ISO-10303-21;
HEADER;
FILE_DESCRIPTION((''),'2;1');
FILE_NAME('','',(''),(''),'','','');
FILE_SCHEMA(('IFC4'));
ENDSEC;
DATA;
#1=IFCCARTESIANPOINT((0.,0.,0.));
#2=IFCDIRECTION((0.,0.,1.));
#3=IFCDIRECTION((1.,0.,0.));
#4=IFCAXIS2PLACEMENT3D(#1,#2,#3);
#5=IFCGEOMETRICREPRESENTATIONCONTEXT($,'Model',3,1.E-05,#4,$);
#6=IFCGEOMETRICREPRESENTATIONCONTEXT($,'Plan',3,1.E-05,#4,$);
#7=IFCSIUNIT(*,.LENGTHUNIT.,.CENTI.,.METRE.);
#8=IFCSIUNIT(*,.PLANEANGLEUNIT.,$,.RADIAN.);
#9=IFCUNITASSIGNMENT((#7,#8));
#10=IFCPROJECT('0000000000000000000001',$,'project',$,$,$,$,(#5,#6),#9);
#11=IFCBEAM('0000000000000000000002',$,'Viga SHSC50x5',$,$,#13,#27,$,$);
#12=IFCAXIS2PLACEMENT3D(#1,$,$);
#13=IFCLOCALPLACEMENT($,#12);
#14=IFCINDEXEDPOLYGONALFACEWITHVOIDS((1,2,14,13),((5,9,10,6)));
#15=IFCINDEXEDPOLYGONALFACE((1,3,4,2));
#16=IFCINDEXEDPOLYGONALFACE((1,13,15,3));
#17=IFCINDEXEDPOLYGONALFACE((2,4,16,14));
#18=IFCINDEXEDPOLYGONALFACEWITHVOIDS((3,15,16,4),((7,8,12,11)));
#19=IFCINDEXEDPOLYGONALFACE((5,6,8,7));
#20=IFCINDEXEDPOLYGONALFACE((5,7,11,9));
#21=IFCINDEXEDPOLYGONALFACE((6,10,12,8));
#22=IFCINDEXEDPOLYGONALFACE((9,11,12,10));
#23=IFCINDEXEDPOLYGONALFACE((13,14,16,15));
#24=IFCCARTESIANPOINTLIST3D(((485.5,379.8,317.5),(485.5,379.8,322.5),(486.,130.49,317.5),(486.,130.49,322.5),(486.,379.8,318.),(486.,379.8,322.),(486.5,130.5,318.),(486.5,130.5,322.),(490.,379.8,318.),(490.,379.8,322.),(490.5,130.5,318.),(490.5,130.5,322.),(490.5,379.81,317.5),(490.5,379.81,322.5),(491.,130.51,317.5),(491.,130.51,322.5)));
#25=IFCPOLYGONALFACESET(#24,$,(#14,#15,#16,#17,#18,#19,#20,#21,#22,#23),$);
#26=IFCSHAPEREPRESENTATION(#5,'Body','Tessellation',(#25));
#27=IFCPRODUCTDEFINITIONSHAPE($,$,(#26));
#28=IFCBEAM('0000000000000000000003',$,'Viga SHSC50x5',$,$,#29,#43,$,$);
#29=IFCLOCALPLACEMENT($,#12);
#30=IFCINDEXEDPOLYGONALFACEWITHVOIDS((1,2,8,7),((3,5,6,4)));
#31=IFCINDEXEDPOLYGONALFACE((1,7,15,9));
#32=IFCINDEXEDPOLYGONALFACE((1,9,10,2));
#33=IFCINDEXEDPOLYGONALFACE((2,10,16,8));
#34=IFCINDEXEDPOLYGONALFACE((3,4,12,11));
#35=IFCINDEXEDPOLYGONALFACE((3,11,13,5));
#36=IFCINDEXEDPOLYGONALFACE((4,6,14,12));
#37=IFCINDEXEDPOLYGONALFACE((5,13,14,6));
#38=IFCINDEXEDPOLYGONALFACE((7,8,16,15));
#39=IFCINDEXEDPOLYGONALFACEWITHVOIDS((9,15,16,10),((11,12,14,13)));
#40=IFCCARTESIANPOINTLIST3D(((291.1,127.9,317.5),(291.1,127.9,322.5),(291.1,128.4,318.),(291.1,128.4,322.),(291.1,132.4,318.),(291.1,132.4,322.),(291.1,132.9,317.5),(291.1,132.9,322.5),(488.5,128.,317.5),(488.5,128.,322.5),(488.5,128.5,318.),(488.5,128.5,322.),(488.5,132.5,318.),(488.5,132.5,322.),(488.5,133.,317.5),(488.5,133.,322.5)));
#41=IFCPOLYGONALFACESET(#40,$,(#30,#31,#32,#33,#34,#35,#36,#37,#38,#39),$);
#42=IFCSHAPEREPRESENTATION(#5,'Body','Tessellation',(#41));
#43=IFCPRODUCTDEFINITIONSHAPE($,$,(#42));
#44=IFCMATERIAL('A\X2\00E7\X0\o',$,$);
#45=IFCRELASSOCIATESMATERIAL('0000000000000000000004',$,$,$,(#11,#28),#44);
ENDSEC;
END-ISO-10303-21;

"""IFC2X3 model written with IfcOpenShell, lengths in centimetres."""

from ifc_helpers import new_model, si_unit, frame, frame_2d, origin_with_axes, place, context, project, polyline, rectangle, outline, extrude, material, element, save


model = new_model("IFC2X3")

# Units and contexts
model_context = context("Model", 3, precision=1e-05, world=origin_with_axes())
plan_context = context("Plan", 3, precision=1e-05, world=origin_with_axes())
ifc_project = project(units=[si_unit("LENGTHUNIT", "METRE", prefix="CENTI"), si_unit("PLANEANGLEUNIT", "RADIAN")], contexts=[model_context, plan_context])

# Shared definitions
ifc_material = material(Name="Aço")

# Beams, openings
placement_1 = place(None, frame((488.5, 130.5, 320.0), z_axis=(-0.002006, 0.999998, 0.0), x_axis=(0.999998, 0.002006, 0.0)))
beam_1 = element("IfcBeam", 1, at=placement_1, material=ifc_material, Name="Viga SHSC50x5", context=model_context, shape_type="SweptSolid", body=[
    extrude(rectangle(XDim=5.0, YDim=5.0, at=frame_2d((0.0, 0.0), x_axis=(1.0, 0.0))), origin_with_axes(), (0.0, 0.0, 1.0), 249.3),
])
element("IfcOpeningElement", 2, at=placement_1, cuts=beam_1, context=model_context, shape_type="SweptSolid", body=[
    extrude(outline(polyline([(2.0, -2.0), (-2.0, -2.0), (-2.0, 2.0), (2.0, 2.0), (2.0, -2.0)])), origin_with_axes(), (0.0, 0.0, 1.0), 249.3),
])
placement_2 = place(None, frame((291.1, 130.4, 320.0), z_axis=(1.0, 0.000507, 0.0), x_axis=(0.000507, -1.0, 0.0)))
beam_2 = element("IfcBeam", 3, at=placement_2, material=ifc_material, Name="Viga SHSC50x5", context=model_context, shape_type="SweptSolid", body=[
    extrude(rectangle(XDim=5.0, YDim=5.0, at=frame_2d((0.0, 0.0), x_axis=(1.0, 0.0))), origin_with_axes(), (0.0, 0.0, 1.0), 197.4),
])
element("IfcOpeningElement", 4, at=placement_2, cuts=beam_2, context=model_context, shape_type="SweptSolid", body=[
    extrude(outline(polyline([(2.0, -2.0), (-2.0, -2.0), (-2.0, 2.0), (2.0, 2.0), (2.0, -2.0)])), origin_with_axes(), (0.0, 0.0, 1.0), 197.4),
])

save(model, "model.ifc")
